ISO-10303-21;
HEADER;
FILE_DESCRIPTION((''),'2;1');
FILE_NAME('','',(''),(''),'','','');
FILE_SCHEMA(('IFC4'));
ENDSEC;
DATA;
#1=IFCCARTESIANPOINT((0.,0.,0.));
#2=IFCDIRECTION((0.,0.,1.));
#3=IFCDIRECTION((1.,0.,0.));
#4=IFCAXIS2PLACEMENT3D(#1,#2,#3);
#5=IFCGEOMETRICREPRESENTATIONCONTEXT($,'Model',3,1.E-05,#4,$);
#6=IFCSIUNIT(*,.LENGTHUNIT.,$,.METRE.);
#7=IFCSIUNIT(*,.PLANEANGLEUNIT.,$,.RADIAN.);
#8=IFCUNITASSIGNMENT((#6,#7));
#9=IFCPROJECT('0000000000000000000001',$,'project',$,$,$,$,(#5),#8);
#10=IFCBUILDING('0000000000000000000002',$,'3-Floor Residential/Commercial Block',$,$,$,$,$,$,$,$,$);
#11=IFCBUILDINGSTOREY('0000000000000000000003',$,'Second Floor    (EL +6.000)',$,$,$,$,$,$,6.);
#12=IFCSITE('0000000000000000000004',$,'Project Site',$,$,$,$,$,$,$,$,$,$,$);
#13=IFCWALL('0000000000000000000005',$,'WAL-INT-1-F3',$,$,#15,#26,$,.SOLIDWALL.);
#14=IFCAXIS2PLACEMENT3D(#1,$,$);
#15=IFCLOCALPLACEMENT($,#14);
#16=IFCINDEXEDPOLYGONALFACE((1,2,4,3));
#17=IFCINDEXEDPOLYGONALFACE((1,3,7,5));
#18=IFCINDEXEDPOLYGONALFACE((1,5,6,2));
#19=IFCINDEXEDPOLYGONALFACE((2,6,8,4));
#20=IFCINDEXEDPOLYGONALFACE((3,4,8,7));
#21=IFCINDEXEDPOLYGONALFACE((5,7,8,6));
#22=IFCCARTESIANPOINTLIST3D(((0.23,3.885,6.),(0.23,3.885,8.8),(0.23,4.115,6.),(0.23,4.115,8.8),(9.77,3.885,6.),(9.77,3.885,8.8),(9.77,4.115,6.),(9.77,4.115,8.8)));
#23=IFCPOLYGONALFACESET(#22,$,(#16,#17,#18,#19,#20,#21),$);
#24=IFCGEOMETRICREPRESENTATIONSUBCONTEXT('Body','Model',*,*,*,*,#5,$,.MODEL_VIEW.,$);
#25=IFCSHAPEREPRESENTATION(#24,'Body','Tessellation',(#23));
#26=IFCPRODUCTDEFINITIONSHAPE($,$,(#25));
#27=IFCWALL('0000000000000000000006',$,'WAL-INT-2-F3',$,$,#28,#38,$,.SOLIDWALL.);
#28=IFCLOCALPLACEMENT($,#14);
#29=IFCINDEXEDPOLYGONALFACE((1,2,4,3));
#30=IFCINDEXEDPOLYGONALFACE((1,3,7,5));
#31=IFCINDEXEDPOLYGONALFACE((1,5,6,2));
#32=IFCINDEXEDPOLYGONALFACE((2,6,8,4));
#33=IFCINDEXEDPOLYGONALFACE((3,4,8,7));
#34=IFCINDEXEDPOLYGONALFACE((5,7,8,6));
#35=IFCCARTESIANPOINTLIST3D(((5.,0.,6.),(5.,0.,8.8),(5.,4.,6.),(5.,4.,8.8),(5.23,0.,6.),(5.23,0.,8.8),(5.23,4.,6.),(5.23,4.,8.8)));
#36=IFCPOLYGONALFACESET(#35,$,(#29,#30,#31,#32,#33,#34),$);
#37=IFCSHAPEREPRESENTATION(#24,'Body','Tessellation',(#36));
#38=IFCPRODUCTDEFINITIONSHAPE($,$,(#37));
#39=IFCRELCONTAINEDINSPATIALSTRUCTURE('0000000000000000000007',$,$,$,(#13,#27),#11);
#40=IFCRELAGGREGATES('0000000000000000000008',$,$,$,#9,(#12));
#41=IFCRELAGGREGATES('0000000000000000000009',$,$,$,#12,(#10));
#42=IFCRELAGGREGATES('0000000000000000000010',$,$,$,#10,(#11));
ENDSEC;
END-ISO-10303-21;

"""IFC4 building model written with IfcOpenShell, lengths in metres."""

from ifc_helpers import new_model, si_unit, frame, frame_2d, origin_with_axes, place, context, subcontext, project, spatial, rectangle, extrude, element, save


model = new_model("IFC4")

# Units and contexts
model_context = context("Model", 3, precision=1e-05, world=origin_with_axes())
body_context = subcontext(model_context, "Body", "Model", "MODEL_VIEW")
ifc_project = project(units=[si_unit("LENGTHUNIT", "METRE"), si_unit("PLANEANGLEUNIT", "RADIAN")], contexts=[model_context])

# Site, building, storey
site = spatial("IfcSite", under=ifc_project, Name="Project Site")
building = spatial("IfcBuilding", under=site, Name="3-Floor Residential/Commercial Block")
storey = spatial("IfcBuildingStorey", under=building, Name="Second Floor    (EL +6.000)", Elevation=6.0)

# Walls
wall_1_placement = place(None, frame((0.23, 3.885, 6.0), z_axis=(0.0, 0.0, 1.0), x_axis=(1.0, 0.0, 0.0)))
element("IfcWall", 1, at=wall_1_placement, inside=storey, Name="WAL-INT-1-F3", PredefinedType="SOLIDWALL", context=body_context, shape_type="SweptSolid", body=[
    extrude(rectangle(XDim=9.54, YDim=0.23, at=frame_2d((4.77, 0.115))), origin_with_axes(), (0.0, 0.0, 1.0), 2.8),
])
wall_2_placement = place(None, frame((5.0, 0.0, 6.0), z_axis=(0.0, 0.0, 1.0), x_axis=(1.0, 0.0, 0.0)))
element("IfcWall", 2, at=wall_2_placement, inside=storey, Name="WAL-INT-2-F3", PredefinedType="SOLIDWALL", context=body_context, shape_type="SweptSolid", body=[
    extrude(rectangle(XDim=0.23, YDim=4.0, at=frame_2d((0.115, 2.0))), origin_with_axes(), (0.0, 0.0, 1.0), 2.8),
])

save(model, "model.ifc")
